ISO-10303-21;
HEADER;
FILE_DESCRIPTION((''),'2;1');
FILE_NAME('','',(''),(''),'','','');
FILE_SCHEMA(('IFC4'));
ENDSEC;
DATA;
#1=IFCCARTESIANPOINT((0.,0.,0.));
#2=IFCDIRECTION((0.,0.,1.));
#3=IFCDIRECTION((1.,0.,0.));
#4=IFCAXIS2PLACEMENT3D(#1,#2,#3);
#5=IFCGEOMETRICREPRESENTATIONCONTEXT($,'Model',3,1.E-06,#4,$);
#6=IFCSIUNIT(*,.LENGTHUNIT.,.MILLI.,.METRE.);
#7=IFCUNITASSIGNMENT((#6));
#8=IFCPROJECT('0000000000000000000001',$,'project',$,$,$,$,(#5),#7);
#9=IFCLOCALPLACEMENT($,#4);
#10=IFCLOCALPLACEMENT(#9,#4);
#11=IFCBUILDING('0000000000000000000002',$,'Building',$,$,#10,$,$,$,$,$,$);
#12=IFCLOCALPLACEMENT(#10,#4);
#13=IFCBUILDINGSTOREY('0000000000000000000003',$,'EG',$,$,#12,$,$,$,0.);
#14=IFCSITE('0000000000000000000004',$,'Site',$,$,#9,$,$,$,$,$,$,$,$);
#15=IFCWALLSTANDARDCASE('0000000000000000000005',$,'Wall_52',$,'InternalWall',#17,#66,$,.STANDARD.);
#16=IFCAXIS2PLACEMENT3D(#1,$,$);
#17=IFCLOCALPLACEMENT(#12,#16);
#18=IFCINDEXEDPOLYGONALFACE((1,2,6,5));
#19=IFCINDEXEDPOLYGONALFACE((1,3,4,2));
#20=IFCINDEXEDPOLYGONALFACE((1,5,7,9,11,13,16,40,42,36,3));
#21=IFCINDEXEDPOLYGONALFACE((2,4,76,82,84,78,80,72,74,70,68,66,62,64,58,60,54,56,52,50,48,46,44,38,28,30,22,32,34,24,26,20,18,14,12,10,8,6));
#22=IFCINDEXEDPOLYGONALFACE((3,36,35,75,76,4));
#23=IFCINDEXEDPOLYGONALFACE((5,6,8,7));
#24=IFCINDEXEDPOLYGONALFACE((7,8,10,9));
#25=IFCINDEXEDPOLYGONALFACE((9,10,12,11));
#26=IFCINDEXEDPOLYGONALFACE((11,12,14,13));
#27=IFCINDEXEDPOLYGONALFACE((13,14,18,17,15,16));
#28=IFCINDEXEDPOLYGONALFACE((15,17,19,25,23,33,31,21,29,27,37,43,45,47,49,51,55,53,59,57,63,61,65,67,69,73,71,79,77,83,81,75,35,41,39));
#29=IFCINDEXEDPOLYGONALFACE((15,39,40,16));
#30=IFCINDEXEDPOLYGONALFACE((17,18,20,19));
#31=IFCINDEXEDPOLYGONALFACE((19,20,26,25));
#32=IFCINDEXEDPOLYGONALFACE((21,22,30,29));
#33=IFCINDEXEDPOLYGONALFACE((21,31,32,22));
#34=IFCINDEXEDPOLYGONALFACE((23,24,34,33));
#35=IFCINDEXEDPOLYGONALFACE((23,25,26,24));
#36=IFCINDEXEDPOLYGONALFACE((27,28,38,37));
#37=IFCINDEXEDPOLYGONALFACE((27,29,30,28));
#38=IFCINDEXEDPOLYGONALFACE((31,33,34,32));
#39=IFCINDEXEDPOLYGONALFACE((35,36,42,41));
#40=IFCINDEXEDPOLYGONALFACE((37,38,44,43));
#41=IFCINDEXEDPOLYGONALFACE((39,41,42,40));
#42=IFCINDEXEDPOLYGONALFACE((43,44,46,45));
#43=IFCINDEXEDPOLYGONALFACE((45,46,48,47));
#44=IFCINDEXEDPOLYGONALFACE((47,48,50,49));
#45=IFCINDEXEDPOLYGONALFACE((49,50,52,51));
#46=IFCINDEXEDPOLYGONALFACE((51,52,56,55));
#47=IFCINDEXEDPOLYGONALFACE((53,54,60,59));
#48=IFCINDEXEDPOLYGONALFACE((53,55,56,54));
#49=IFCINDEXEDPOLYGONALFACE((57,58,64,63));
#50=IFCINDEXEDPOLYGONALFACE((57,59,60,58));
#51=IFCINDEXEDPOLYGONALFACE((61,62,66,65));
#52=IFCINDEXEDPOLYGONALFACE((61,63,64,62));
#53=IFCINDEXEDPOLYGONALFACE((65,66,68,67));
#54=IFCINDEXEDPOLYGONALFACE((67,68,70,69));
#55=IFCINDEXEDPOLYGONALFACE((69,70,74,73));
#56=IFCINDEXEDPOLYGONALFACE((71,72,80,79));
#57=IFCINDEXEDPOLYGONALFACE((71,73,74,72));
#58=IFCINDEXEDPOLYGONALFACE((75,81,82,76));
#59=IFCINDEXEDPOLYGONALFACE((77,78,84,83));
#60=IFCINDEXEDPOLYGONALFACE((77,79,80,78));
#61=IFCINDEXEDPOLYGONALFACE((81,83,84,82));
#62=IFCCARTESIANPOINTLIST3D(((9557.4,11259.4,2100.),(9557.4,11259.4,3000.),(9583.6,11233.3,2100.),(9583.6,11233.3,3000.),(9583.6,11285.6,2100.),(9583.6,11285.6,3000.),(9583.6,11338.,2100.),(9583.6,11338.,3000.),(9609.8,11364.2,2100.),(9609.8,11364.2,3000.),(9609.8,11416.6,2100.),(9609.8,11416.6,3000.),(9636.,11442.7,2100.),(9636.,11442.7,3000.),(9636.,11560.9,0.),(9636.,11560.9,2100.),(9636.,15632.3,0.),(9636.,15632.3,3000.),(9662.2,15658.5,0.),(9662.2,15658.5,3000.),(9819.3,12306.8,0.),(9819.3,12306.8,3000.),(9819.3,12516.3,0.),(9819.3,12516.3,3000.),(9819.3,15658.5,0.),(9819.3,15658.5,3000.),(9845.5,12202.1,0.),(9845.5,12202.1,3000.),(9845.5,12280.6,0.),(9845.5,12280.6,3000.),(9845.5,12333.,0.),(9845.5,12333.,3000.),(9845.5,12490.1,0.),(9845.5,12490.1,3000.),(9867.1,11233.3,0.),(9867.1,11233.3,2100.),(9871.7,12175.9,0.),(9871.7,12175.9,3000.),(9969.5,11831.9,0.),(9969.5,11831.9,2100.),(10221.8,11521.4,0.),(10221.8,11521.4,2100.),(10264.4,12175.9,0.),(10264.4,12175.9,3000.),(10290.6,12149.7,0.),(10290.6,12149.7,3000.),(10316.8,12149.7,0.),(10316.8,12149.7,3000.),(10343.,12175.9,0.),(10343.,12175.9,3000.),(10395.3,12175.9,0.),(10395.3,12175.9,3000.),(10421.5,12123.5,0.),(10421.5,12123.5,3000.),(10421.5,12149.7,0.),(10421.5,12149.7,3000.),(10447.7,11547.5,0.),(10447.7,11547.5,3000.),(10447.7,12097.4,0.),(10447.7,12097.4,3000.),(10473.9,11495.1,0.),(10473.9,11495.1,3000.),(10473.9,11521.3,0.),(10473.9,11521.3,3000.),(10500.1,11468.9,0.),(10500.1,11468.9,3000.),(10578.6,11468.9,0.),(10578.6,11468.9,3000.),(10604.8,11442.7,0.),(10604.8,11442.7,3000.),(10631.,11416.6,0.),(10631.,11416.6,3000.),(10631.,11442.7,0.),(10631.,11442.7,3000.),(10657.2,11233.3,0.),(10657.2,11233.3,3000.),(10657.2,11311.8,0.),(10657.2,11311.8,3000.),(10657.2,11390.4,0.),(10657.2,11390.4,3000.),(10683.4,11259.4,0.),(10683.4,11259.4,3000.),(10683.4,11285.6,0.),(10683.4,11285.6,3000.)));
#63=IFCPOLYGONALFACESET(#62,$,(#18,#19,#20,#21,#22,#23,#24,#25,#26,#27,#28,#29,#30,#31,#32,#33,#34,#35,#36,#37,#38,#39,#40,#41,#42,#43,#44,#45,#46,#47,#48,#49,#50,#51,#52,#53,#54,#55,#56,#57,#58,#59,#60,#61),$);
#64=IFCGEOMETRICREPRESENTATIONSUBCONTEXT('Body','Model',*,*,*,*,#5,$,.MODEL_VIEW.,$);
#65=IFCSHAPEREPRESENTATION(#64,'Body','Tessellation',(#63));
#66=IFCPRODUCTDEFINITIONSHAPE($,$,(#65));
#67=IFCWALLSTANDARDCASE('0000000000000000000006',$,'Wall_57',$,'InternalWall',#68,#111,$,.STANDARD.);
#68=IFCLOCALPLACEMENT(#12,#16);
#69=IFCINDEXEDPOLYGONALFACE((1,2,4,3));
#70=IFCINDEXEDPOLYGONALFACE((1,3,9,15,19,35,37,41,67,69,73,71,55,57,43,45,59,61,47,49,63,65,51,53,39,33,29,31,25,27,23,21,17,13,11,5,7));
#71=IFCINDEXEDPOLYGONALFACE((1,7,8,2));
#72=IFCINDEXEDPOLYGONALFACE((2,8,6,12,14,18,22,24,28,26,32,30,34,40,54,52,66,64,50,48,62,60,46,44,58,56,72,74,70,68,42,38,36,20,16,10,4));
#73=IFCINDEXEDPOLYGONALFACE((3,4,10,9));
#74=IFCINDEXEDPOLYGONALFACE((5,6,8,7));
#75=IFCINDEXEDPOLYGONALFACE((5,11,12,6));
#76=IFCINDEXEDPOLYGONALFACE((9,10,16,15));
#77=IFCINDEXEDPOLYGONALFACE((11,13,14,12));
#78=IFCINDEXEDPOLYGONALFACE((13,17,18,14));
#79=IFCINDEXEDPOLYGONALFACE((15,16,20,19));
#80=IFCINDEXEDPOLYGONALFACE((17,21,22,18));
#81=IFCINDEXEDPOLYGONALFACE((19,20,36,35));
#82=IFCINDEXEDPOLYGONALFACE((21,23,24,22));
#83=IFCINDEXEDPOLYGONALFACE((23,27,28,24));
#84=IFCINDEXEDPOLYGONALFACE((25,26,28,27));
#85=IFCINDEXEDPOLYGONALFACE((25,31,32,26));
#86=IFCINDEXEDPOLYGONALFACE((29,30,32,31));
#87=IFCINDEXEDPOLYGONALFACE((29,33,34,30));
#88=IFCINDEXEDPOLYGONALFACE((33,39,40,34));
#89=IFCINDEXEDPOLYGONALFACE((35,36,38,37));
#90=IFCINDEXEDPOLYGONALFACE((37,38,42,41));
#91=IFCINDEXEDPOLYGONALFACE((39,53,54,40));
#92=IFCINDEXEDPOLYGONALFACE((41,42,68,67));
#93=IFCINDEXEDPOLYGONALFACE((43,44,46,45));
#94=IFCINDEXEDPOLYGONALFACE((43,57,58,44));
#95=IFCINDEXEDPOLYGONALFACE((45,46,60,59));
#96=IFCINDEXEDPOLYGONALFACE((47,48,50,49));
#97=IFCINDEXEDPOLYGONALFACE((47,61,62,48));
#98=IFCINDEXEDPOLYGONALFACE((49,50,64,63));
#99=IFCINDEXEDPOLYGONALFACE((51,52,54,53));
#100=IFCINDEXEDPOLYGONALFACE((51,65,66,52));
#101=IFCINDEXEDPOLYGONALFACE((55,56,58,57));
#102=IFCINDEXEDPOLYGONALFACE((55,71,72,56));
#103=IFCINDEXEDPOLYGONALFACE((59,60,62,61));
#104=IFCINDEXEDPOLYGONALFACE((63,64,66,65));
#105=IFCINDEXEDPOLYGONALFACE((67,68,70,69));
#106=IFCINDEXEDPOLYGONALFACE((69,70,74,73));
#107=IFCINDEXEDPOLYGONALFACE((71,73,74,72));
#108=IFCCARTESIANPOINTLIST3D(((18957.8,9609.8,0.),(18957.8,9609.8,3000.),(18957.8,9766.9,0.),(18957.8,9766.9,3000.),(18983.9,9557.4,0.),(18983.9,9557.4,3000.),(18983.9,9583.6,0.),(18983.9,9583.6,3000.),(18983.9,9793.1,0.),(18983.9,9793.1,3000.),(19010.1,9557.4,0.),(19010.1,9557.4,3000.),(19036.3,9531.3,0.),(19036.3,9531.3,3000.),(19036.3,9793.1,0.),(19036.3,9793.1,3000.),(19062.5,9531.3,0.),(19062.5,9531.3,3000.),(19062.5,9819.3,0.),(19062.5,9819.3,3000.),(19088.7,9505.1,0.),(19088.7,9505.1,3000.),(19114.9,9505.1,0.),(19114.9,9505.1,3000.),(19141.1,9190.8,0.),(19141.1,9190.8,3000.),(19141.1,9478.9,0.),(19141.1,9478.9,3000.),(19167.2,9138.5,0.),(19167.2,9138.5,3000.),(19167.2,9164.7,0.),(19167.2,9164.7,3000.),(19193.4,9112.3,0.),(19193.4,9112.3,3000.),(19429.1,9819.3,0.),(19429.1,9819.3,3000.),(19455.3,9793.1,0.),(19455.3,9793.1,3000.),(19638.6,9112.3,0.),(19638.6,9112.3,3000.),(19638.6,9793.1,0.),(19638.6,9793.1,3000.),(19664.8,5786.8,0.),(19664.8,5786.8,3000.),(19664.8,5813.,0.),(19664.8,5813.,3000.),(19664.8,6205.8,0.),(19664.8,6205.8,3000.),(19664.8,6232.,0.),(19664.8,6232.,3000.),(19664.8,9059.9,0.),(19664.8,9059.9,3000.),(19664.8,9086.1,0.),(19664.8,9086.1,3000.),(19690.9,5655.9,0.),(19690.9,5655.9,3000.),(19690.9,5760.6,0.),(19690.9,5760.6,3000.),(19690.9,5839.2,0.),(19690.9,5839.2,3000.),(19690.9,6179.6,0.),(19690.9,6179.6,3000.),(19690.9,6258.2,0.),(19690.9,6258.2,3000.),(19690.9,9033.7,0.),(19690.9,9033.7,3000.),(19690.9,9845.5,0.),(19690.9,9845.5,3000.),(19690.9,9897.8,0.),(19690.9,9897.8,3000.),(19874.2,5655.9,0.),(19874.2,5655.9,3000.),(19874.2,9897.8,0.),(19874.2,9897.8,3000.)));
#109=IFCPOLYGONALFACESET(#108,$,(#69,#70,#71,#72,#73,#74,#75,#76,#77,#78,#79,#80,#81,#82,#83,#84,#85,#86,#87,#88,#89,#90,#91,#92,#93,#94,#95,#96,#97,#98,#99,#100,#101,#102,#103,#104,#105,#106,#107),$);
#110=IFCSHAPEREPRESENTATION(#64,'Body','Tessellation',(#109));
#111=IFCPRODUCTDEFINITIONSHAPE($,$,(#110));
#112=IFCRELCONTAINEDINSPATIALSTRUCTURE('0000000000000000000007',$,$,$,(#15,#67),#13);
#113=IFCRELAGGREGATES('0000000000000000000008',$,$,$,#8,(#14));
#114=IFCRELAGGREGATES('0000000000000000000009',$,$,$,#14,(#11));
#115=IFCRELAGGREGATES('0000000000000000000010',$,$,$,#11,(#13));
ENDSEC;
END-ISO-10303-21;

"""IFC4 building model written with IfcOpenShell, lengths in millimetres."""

from ifc_helpers import new_model, si_unit, frame, origin_with_axes, place, context, subcontext, project, spatial, polyline, rectangle, outline, extrude, element, save


model = new_model("IFC4")

# Units and contexts
model_context = context("Model", 3, precision=1e-06, world=origin_with_axes())
body_context = subcontext(model_context, "Body", "Model", "MODEL_VIEW")
ifc_project = project(units=[si_unit("LENGTHUNIT", "METRE", prefix="MILLI")], contexts=[model_context])

# Site, building, storey
site_placement = place(None, origin_with_axes())
site = spatial("IfcSite", under=ifc_project, at=site_placement, Name="Site")
building_placement = place(site_placement, origin_with_axes())
building = spatial("IfcBuilding", under=site, at=building_placement, Name="Building")
storey_placement = place(building_placement, origin_with_axes())
storey = spatial("IfcBuildingStorey", under=building, at=storey_placement, Name="EG", Elevation=0.0)

# Wall, opening
wall_1_placement = place(storey_placement, origin_with_axes())
wall_1 = element("IfcWallStandardCase", 1, at=wall_1_placement, inside=storey, Name="Wall_52", ObjectType="InternalWall", PredefinedType="STANDARD", context=body_context, shape_type="SweptSolid", body=[
    extrude(outline(polyline([(9583.6, 11233.3, 0.0), (9557.4, 11259.4, 0.0), (9583.6, 11285.6, 0.0), (9583.6, 11338.0, 0.0), (9609.8, 11364.2, 0.0), (9609.8, 11416.6, 0.0), (9636.0, 11442.7, 0.0), (9636.0, 15632.3, 0.0), (9662.2, 15658.5, 0.0), (9819.3, 15658.5, 0.0), (9819.3, 12516.3, 0.0), (9845.5, 12490.1, 0.0), (9845.5, 12333.0, 0.0), (9819.3, 12306.8, 0.0), (9845.5, 12280.6, 0.0), (9845.5, 12202.1, 0.0), (9871.7, 12175.9, 0.0), (10264.4, 12175.9, 0.0), (10290.6, 12149.7, 0.0), (10316.8, 12149.7, 0.0), (10343.0, 12175.9, 0.0), (10395.3, 12175.9, 0.0), (10421.5, 12149.7, 0.0), (10421.5, 12123.5, 0.0), (10447.7, 12097.4, 0.0), (10447.7, 11547.5, 0.0), (10473.9, 11521.3, 0.0), (10473.9, 11495.1, 0.0), (10500.1, 11468.9, 0.0), (10578.6, 11468.9, 0.0), (10604.8, 11442.7, 0.0), (10631.0, 11442.7, 0.0), (10631.0, 11416.6, 0.0), (10657.2, 11390.4, 0.0), (10657.2, 11311.8, 0.0), (10683.4, 11285.6, 0.0), (10683.4, 11259.4, 0.0), (10657.2, 11233.3, 0.0), (9583.6, 11233.3, 0.0)])), origin_with_axes(), (0.0, 0.0, 1.0), 3000.0),
])
opening_1_placement = place(wall_1_placement, origin_with_axes())
element("IfcOpeningElement", 2, at=opening_1_placement, inside=storey, cuts=wall_1, context=body_context, shape_type="SweptSolid", body=[
    extrude(rectangle(XDim=1327.3, YDim=400.0), frame((9580.6, 11258.1, 0.0), z_axis=(0.0, 0.0, 1.0), x_axis=(-0.776114, -0.630593, 0.0)), (0.0, 0.0, 1.0), 2100.0),
])

# Wall
for number, where, z_axis, x_axis, name in (
    (3, (0.0, 0.0, 0.0), (0.0, 0.0, 1.0), (1.0, 0.0, 0.0), "Wall_57"),
):
    element("IfcWallStandardCase", number, at=place(storey_placement, frame(where, z_axis=z_axis, x_axis=x_axis)), inside=storey, Name=name, ObjectType="InternalWall", PredefinedType="STANDARD", context=body_context, shape_type="SweptSolid", body=[
        extrude(outline(polyline([(19690.9, 5655.9, 0.0), (19690.9, 5760.6, 0.0), (19664.8, 5786.8, 0.0), (19664.8, 5813.0, 0.0), (19690.9, 5839.2, 0.0), (19690.9, 6179.6, 0.0), (19664.8, 6205.8, 0.0), (19664.8, 6232.0, 0.0), (19690.9, 6258.2, 0.0), (19690.9, 9033.7, 0.0), (19664.8, 9059.9, 0.0), (19664.8, 9086.1, 0.0), (19638.6, 9112.3, 0.0), (19193.4, 9112.3, 0.0), (19167.2, 9138.5, 0.0), (19167.2, 9164.7, 0.0), (19141.1, 9190.8, 0.0), (19141.1, 9478.9, 0.0), (19114.9, 9505.1, 0.0), (19088.7, 9505.1, 0.0), (19062.5, 9531.3, 0.0), (19036.3, 9531.3, 0.0), (19010.1, 9557.4, 0.0), (18983.9, 9557.4, 0.0), (18983.9, 9583.6, 0.0), (18957.8, 9609.8, 0.0), (18957.8, 9766.9, 0.0), (18983.9, 9793.1, 0.0), (19036.3, 9793.1, 0.0), (19062.5, 9819.3, 0.0), (19429.1, 9819.3, 0.0), (19455.3, 9793.1, 0.0), (19638.6, 9793.1, 0.0), (19690.9, 9845.5, 0.0), (19690.9, 9897.8, 0.0), (19874.2, 9897.8, 0.0), (19874.2, 5655.9, 0.0), (19690.9, 5655.9, 0.0)])), origin_with_axes(), (0.0, 0.0, 1.0), 3000.0),
    ])

save(model, "model.ifc")
